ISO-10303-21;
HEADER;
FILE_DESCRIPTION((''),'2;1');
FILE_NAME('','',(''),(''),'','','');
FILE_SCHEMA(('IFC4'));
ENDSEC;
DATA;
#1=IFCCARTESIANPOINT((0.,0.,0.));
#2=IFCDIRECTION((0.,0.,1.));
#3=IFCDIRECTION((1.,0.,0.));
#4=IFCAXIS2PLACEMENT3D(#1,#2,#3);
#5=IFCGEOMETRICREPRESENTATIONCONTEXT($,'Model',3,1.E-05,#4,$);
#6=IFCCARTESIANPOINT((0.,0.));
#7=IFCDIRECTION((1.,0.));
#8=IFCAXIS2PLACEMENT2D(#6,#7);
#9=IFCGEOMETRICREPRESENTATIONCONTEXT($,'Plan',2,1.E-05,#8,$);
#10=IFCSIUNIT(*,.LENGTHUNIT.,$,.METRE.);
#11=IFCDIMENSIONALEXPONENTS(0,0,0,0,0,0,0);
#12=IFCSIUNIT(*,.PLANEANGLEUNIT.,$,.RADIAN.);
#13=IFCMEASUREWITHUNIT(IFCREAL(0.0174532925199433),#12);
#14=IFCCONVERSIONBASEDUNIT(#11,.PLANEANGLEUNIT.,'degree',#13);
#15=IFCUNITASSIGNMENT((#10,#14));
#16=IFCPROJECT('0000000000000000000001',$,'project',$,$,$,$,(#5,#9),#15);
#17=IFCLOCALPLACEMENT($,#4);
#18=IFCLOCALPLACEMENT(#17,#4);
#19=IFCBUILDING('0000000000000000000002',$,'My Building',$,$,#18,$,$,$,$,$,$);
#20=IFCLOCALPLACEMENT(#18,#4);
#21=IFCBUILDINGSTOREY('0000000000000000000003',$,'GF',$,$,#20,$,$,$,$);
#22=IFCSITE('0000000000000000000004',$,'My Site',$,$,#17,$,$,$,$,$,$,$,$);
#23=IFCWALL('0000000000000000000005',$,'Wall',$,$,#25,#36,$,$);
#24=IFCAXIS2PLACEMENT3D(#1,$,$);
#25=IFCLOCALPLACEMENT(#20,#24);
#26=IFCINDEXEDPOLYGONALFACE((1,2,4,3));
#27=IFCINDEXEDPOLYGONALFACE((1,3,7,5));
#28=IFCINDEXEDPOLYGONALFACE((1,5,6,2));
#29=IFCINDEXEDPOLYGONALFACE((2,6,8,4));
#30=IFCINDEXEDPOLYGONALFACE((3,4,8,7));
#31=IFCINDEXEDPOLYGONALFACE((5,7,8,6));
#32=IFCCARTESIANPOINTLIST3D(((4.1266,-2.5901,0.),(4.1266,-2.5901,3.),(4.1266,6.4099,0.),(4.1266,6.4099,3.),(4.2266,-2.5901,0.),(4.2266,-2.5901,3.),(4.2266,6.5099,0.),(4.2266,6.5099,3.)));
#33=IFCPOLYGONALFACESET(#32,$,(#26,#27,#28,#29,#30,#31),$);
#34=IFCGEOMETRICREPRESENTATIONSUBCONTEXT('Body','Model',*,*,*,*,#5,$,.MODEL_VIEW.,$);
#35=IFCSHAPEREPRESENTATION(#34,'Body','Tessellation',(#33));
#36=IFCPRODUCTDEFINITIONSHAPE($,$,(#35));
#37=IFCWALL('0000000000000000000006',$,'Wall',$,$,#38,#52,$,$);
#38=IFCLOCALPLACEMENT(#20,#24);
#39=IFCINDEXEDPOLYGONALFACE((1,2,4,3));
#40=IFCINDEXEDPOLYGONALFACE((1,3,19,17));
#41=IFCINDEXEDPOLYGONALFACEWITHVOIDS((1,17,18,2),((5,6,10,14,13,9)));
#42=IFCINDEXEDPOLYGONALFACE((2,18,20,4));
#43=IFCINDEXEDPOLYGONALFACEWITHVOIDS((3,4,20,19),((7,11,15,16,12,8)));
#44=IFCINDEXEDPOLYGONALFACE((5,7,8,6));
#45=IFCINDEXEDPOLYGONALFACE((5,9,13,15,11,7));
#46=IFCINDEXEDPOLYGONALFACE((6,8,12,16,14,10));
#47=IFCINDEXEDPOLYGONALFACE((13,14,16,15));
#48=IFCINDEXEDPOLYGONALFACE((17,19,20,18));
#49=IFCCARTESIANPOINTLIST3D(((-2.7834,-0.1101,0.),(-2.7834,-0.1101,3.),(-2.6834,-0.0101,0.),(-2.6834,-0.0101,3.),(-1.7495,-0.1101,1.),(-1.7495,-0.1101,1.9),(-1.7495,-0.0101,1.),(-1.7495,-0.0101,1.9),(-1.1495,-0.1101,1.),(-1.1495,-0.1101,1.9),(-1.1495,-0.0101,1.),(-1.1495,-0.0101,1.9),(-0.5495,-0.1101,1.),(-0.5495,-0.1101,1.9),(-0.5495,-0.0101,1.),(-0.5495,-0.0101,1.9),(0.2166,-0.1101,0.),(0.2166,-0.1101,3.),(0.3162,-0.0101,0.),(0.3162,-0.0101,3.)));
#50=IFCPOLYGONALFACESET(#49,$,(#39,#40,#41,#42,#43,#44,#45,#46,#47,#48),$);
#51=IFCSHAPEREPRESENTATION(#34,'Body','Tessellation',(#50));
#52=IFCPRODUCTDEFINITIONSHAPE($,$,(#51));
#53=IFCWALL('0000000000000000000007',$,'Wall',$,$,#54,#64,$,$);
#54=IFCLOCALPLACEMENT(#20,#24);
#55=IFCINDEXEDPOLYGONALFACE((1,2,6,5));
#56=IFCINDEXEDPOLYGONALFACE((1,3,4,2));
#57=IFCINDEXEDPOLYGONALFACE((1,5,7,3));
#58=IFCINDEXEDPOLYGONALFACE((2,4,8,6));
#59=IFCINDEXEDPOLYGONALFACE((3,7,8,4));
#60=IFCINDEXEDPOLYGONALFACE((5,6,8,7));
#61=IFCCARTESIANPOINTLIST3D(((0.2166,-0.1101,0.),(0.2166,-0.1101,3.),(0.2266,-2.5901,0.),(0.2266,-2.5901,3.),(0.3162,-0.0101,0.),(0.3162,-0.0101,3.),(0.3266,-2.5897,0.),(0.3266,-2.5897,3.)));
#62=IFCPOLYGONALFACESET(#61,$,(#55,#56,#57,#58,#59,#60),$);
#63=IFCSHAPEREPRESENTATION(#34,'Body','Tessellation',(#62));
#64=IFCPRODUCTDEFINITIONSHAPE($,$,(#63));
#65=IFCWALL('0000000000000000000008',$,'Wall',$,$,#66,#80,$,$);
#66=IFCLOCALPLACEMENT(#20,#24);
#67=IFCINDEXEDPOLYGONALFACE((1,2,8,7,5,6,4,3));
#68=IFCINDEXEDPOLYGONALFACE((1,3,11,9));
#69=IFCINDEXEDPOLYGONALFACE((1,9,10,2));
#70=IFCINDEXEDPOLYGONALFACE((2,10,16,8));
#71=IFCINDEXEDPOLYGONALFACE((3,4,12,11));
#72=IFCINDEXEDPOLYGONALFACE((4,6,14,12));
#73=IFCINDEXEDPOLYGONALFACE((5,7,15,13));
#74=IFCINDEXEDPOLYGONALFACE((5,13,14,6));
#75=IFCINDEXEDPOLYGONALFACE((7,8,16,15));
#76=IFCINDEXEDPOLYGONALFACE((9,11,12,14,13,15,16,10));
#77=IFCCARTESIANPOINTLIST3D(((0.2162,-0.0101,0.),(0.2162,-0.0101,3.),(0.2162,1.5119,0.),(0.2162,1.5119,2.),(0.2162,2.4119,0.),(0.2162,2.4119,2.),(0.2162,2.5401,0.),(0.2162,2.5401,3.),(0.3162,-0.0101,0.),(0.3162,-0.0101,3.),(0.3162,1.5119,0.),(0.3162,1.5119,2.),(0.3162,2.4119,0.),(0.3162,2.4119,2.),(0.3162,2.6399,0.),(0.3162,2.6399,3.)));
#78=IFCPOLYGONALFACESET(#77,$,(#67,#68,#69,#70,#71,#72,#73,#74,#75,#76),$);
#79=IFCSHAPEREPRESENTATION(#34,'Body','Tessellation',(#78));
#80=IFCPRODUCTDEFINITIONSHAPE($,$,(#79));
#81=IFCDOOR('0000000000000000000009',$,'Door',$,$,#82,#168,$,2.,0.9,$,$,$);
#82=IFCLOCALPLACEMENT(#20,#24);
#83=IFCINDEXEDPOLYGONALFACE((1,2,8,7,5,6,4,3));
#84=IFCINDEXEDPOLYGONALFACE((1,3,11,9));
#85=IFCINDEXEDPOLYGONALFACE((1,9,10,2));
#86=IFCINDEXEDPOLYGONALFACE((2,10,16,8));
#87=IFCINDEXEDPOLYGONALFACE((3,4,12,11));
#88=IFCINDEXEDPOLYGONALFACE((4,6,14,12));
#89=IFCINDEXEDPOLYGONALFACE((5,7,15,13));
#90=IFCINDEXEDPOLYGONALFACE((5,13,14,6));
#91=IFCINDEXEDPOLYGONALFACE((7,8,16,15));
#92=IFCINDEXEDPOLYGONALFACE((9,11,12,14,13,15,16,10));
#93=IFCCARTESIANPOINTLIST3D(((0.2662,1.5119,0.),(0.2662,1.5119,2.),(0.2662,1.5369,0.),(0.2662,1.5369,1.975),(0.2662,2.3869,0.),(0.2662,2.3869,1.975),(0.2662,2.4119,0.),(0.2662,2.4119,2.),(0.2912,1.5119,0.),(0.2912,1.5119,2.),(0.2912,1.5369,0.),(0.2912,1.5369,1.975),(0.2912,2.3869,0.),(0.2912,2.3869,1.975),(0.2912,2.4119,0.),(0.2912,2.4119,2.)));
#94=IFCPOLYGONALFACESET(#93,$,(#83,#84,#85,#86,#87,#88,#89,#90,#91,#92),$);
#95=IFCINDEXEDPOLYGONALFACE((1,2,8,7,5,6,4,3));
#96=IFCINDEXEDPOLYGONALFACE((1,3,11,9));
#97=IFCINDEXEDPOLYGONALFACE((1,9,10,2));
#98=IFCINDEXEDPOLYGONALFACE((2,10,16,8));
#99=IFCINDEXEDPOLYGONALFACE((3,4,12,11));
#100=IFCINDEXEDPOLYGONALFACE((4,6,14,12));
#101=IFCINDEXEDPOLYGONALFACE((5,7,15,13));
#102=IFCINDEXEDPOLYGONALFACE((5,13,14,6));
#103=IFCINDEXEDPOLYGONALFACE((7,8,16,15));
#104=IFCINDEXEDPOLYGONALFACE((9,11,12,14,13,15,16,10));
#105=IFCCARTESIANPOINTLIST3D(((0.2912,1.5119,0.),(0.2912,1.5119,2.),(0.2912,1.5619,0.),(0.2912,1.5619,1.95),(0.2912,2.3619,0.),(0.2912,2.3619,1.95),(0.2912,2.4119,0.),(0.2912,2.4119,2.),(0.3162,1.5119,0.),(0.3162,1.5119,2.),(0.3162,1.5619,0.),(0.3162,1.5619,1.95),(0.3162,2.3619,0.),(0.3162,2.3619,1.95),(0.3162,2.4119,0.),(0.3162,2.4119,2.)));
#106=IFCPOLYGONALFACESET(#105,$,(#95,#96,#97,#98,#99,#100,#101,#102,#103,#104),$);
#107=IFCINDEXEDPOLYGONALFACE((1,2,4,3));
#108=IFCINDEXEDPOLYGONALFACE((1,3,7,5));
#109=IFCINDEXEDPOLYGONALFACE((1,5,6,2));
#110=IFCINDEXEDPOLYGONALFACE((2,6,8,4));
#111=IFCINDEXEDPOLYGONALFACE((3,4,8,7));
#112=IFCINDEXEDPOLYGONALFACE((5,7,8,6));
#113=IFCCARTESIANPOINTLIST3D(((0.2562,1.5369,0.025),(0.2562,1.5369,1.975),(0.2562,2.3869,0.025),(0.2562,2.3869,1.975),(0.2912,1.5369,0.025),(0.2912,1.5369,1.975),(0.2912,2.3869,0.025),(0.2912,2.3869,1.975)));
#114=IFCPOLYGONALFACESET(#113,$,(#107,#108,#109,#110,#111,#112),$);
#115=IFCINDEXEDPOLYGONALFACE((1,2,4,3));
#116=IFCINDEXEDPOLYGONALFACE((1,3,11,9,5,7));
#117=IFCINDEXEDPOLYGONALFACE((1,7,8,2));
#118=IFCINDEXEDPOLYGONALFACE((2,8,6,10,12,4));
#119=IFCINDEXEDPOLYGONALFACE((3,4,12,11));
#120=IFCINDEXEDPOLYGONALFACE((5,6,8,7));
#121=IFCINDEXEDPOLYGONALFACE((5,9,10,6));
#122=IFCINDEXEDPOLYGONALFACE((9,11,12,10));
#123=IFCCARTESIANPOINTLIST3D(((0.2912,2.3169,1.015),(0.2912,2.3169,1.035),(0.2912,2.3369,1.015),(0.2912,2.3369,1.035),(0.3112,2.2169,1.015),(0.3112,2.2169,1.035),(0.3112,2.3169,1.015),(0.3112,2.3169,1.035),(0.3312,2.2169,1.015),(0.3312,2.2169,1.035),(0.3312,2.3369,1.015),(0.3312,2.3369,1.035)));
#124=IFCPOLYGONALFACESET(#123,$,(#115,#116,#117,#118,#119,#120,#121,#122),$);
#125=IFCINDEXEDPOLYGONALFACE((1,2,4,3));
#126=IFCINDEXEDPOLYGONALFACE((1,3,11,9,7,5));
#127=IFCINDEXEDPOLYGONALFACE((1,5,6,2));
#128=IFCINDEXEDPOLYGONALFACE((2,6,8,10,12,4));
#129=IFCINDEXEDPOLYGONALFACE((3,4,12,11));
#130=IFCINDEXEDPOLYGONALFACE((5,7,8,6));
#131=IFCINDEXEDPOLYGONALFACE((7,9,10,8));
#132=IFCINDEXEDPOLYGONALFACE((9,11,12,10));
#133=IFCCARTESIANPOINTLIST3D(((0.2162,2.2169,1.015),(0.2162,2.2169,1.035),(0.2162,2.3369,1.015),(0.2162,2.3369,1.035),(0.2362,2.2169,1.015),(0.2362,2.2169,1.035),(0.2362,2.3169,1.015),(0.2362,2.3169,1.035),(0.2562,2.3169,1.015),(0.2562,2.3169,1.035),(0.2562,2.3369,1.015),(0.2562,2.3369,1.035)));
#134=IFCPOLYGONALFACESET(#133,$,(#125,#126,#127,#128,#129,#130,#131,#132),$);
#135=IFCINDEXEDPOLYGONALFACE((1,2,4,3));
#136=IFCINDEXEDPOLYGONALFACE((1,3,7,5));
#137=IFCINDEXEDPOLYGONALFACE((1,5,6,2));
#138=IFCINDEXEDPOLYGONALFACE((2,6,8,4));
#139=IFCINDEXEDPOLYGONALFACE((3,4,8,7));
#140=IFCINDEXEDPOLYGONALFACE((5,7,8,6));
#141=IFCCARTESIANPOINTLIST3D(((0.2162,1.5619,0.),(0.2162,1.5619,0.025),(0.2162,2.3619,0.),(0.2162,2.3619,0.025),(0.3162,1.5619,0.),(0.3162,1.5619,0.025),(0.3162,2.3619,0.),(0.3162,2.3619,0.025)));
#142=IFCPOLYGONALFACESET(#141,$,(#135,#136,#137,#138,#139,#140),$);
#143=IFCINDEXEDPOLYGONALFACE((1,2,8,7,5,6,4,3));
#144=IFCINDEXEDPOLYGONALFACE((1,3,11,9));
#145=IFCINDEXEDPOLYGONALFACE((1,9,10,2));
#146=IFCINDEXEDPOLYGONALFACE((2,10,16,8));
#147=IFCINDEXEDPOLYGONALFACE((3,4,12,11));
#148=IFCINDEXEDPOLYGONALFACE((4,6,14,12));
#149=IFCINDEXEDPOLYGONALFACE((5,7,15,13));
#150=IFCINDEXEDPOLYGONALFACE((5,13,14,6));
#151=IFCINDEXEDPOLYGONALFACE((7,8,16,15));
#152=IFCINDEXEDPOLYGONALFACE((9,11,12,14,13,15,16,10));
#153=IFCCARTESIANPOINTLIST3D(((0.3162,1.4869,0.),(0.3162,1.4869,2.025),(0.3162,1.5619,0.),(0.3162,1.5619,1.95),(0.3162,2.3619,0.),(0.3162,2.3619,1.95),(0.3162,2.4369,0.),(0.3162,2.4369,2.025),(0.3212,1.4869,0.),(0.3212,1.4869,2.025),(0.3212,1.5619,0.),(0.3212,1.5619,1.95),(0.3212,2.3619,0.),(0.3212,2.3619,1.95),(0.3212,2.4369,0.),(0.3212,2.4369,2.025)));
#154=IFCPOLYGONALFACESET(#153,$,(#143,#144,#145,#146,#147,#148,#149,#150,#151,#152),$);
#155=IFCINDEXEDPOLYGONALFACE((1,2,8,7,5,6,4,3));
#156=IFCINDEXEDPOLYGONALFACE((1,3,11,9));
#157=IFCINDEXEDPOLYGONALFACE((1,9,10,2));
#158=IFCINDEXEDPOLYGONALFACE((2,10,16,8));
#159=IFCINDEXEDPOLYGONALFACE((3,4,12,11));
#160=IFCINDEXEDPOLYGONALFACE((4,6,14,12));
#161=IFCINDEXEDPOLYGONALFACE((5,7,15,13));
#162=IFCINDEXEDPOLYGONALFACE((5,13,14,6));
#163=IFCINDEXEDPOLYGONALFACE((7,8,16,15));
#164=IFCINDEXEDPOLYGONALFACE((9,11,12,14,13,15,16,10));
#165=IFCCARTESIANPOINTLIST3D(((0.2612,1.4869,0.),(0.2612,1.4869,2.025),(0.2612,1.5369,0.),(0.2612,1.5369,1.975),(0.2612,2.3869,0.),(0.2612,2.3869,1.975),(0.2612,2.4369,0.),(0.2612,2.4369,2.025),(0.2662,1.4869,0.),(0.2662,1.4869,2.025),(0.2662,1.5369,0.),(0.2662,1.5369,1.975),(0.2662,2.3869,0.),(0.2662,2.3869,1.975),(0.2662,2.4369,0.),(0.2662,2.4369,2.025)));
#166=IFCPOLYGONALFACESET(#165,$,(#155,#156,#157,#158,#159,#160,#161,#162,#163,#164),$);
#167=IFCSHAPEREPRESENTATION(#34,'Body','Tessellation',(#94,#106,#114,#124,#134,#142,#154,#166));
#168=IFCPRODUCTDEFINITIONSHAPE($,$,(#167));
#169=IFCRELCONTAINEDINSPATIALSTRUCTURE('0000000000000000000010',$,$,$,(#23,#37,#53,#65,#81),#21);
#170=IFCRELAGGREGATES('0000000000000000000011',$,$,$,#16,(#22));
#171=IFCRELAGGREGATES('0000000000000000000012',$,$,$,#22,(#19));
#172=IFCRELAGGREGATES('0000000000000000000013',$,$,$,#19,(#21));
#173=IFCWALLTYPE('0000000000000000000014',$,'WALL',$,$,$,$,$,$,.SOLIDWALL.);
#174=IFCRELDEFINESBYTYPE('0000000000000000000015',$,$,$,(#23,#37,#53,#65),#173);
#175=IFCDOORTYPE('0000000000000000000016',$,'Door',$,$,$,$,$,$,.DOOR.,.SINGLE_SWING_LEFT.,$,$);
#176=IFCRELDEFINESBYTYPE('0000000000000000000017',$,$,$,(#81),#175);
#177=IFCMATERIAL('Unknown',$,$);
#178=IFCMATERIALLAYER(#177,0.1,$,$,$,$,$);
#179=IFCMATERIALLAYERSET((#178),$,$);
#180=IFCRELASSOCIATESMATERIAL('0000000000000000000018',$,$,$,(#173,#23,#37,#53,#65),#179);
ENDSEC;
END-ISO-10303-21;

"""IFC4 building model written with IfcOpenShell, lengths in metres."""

from ifc_helpers import new_model, entity, si_unit, converted_unit, frame, origin_with_axes, origin_2d_with_axis, place, context, subcontext, project, spatial, line, indexed_curve, outline, extrude, shape, source, transform, mapped, material, layer, layer_set, layer_usage, type_object, type_shapes, element, fill, save


model = new_model("IFC4")

# Units and contexts
model_context = context("Model", 3, precision=1e-05, world=origin_with_axes())
plan_context = context("Plan", 2, precision=1e-05, world=origin_2d_with_axis())
body_context_1 = subcontext(model_context, "Body", "Model", "MODEL_VIEW")
body_context_2 = subcontext(plan_context, "Body", "Plan", "PLAN_VIEW")
ifc_project = project(units=[si_unit("LENGTHUNIT", "METRE"), converted_unit("PLANEANGLEUNIT", "degree", entity("IfcReal", 0.0174532925199433), si_unit("PLANEANGLEUNIT", "RADIAN"), dimensions=[0, 0, 0, 0, 0, 0, 0])], contexts=[model_context, plan_context])

# Site, building, storey
site_placement = place(None, origin_with_axes())
site = spatial("IfcSite", under=ifc_project, at=site_placement, Name="My Site")
building_placement = place(site_placement, origin_with_axes())
building = spatial("IfcBuilding", under=site, at=building_placement, Name="My Building")
storey_placement = place(building_placement, origin_with_axes())
storey = spatial("IfcBuildingStorey", under=building, at=storey_placement, Name="GF")

# Shared definitions
ifc_material_1 = material(Name="Unknown")

# Shared definitions
ifc_layer_1 = layer(ifc_material_1, 0.1)
ifc_layer_set_1 = layer_set([ifc_layer_1])
wall_type = type_object("IfcWallType", Name="WALL", PredefinedType="SOLIDWALL", material=ifc_layer_set_1)
shared_shape_1 = source(origin_with_axes(), body_context_1, "Body", "SweptSolid", [
    extrude(outline(indexed_curve([(0.0, 0.0), (0.9, 0.0), (0.9, 2.0), (0.0, 2.0)], segments=[line(1, 2, 3, 4, 1)])), frame((0.0, -0.6, 0.0), z_axis=(0.0, -1.0, 0.0), x_axis=(1.0, 0.0, 0.0)), (0.0, 0.0, -1.0), 1.2),
])
door_type = type_object("IfcDoorType", Name="Door", OperationType="SINGLE_SWING_LEFT", PredefinedType="DOOR")
shared_shape_2 = source(origin_with_axes(), body_context_1, "Body", "SweptSolid", [
    extrude(outline(indexed_curve([(0.0, 0.0), (0.0, 2.0), (0.9, 2.0), (0.9, 0.0), (0.875, 0.0), (0.875, 1.975), (0.025, 1.975), (0.025, 0.0)], segments=[line(1, 2, 3, 4, 5, 6, 7, 8, 1)])), frame((0.0, 0.025, 0.0), z_axis=(0.0, -1.0, 0.0), x_axis=(1.0, 0.0, 0.0)), (0.0, 0.0, -1.0), 0.025),
    extrude(outline(indexed_curve([(0.0, 0.0), (0.0, 2.0), (0.9, 2.0), (0.9, 0.0), (0.85, 0.0), (0.85, 1.95), (0.05, 1.95), (0.05, 0.0)], segments=[line(1, 2, 3, 4, 5, 6, 7, 8, 1)])), frame((0.0, 0.0, 0.0), z_axis=(0.0, -1.0, 0.0), x_axis=(1.0, 0.0, 0.0)), (0.0, 0.0, -1.0), 0.025),
    extrude(outline(indexed_curve([(0.0, 0.0), (0.85, 0.0), (0.85, 0.035), (0.0, 0.035)], segments=[line(1, 2, 3, 4, 1)])), frame((0.025, 0.025, 0.025), z_axis=(0.0, 0.0, 1.0), x_axis=(1.0, 0.0, 0.0)), (0.0, 0.0, 1.0), 1.95),
    extrude(outline(indexed_curve([(0.0, 0.0), (0.0, -0.04), (-0.12, -0.04), (-0.12, -0.02), (-0.02, -0.02), (-0.02, 0.0)], segments=[line(1, 2, 3, 4, 5, 6, 1)])), frame((0.825, 0.025, 1.015), z_axis=(0.0, 0.0, 1.0), x_axis=(1.0, 0.0, 0.0)), (0.0, 0.0, 1.0), 0.02),
    extrude(outline(indexed_curve([(0.0, 0.0), (0.0, 0.04), (-0.12, 0.04), (-0.12, 0.02), (-0.02, 0.02), (-0.02, 0.0)], segments=[line(1, 2, 3, 4, 5, 6, 1)])), frame((0.825, 0.06, 1.015), z_axis=(0.0, 0.0, 1.0), x_axis=(1.0, 0.0, 0.0)), (0.0, 0.0, 1.0), 0.02),
    extrude(outline(indexed_curve([(0.0, 0.0), (0.8, 0.0), (0.8, 0.1), (0.0, 0.1)], segments=[line(1, 2, 3, 4, 1)])), frame((0.05, 0.0, 0.0), z_axis=(0.0, 0.0, 1.0), x_axis=(1.0, 0.0, 0.0)), (0.0, 0.0, 1.0), 0.025),
    extrude(outline(indexed_curve([(0.0, 0.0), (0.0, 2.025), (0.95, 2.025), (0.95, 0.0), (0.875, 0.0), (0.875, 1.95), (0.075, 1.95), (0.075, 0.0)], segments=[line(1, 2, 3, 4, 5, 6, 7, 8, 1)])), frame((-0.025, -0.005, 0.0), z_axis=(0.0, -1.0, 0.0), x_axis=(1.0, 0.0, 0.0)), (0.0, 0.0, -1.0), 0.005),
    extrude(outline(indexed_curve([(0.0, 0.0), (0.0, 2.025), (0.95, 2.025), (0.95, 0.0), (0.9, 0.0), (0.9, 1.975), (0.05, 1.975), (0.05, 0.0)], segments=[line(1, 2, 3, 4, 5, 6, 7, 8, 1)])), frame((-0.025, 0.05, 0.0), z_axis=(0.0, -1.0, 0.0), x_axis=(1.0, 0.0, 0.0)), (0.0, 0.0, -1.0), 0.005),
])
shared_shape_3 = source(origin_with_axes(), body_context_2, "Body", "Curve2D", [
    entity("IfcIndexedPolyCurve", entity("IfcCartesianPointList2D", [[0.0, 0.0], [0.0, 0.05], [0.025, 0.05], [0.025, 0.025], [0.05, 0.025], [0.05, 0.0]]), [entity("IfcLineIndex", [1, 2, 3, 4, 5, 6, 1])]),
    entity("IfcIndexedPolyCurve", entity("IfcCartesianPointList2D", [[0.9, 0.0], [0.9, 0.05], [0.875, 0.05], [0.875, 0.025], [0.85, 0.025], [0.85, 0.0]]), [entity("IfcLineIndex", [1, 2, 3, 4, 5, 6, 1])]),
    entity("IfcTrimmedCurve", entity("IfcEllipse", entity("IfcAxis2Placement2D", entity("IfcCartesianPoint", [0.06, 0.05]), entity("IfcDirection", [1.0, 0.0])), 0.815, 0.85), [entity("IfcCartesianPoint", [0.875, 0.05])], [entity("IfcCartesianPoint", [0.06, 0.9])], True, "CARTESIAN"),
    entity("IfcIndexedPolyCurve", entity("IfcCartesianPointList2D", [[0.025, 0.05], [0.06, 0.05], [0.06, 0.9], [0.025, 0.9]]), [entity("IfcLineIndex", [1, 2, 3, 4, 1])]),
])
type_shapes(door_type, [shared_shape_2, shared_shape_3])

# Wall
ifc_layer_usage_1 = layer_usage(ifc_layer_set_1, "AXIS2", "POSITIVE", 0.0)
wall_1_placement = place(storey_placement, frame((4.2266, -2.5901, 0.0), z_axis=(0.0, 0.0, 1.0), x_axis=(0.0, 1.0, 0.0)))
element("IfcWall", 1, at=wall_1_placement, inside=storey, type_object=wall_type, material=ifc_layer_usage_1, Name="Wall", context=body_context_1, shape_type="SweptSolid", body=[
    extrude(outline(indexed_curve([(0.0, 0.0), (0.0, 0.1), (9.0, 0.1), (9.1, 0.0)], segments=[line(1, 2, 3, 4, 1)])), origin_with_axes(), (0.0, 0.0, 1.0), 3.0),
])

# Wall, openings
ifc_layer_usage_2 = layer_usage(ifc_layer_set_1, "AXIS2", "POSITIVE", 0.0)
wall_2_placement = place(storey_placement, frame((-2.7834, -0.1101, 0.0), z_axis=(0.0, 0.0, 1.0), x_axis=(1.0, 0.0, 0.0)))
wall_2 = element("IfcWall", 2, at=wall_2_placement, inside=storey, type_object=wall_type, material=ifc_layer_usage_2, Name="Wall", context=body_context_1, shape_type="SweptSolid", body=[
    extrude(outline(indexed_curve([(0.0, 0.0), (0.1, 0.1), (3.0996, 0.1), (3.0, 0.0)], segments=[line(1, 2, 3, 4, 1)])), origin_with_axes(), (0.0, 0.0, 1.0), 3.0),
])
shared_shape_4 = source(origin_with_axes(), body_context_1, "Body", "SweptSolid", [
    extrude(outline(indexed_curve([(0.0, 0.0), (0.6, 0.0), (0.6, 0.9), (0.0, 0.9)], segments=[line(1, 2, 3, 4, 1)])), frame((0.0, -0.6, 0.0), z_axis=(0.0, -1.0, 0.0), x_axis=(1.0, 0.0, 0.0)), (0.0, 0.0, -1.0), 1.2),
])
opening_1_placement = place(wall_2_placement, frame((1.0339, 0.0, 1.0), z_axis=(0.0, 0.0, 1.0), x_axis=(1.0, 0.0, 0.0)))
element("IfcOpeningElement", 3, at=opening_1_placement, cuts=wall_2, PredefinedType="OPENING", context=body_context_1, shape_type="MappedRepresentation", body=[
    mapped(shared_shape_4, transform((0.0, 0.0, 0.0), x_axis=(1.0, 0.0, 0.0), y_axis=(0.0, 1.0, 0.0), z_axis=(0.0, 0.0, 1.0), scale=1.0)),
])
opening_2_placement = place(wall_2_placement, frame((1.6339, 0.0, 1.0), z_axis=(0.0, 0.0, 1.0), x_axis=(1.0, 0.0, 0.0)))
element("IfcOpeningElement", 4, at=opening_2_placement, cuts=wall_2, PredefinedType="OPENING", context=body_context_1, shape_type="MappedRepresentation", body=[
    mapped(shared_shape_4, transform((0.0, 0.0, 0.0), x_axis=(1.0, 0.0, 0.0), y_axis=(0.0, 1.0, 0.0), z_axis=(0.0, 0.0, 1.0), scale=1.0)),
])

# Wall
ifc_layer_usage_3 = layer_usage(ifc_layer_set_1, "AXIS2", "POSITIVE", 0.0)
wall_3_placement = place(storey_placement, frame((0.2166, -0.1101, 0.0), z_axis=(0.0, 0.0, 1.0), x_axis=(0.004032, -0.999992, 0.0)))
element("IfcWall", 5, at=wall_3_placement, inside=storey, type_object=wall_type, material=ifc_layer_usage_3, Name="Wall", context=body_context_1, shape_type="SweptSolid", body=[
    extrude(outline(indexed_curve([(0.0, 0.0), (-0.0996, 0.1), (2.48, 0.1), (2.48, 0.0)], segments=[line(1, 2, 3, 4, 1)])), origin_with_axes(), (0.0, 0.0, 1.0), 3.0),
])

# Wall, opening, door
ifc_layer_usage_4 = layer_usage(ifc_layer_set_1, "AXIS2", "POSITIVE", 0.0)
wall_4_placement = place(storey_placement, frame((0.3162, -0.0101, 0.0), z_axis=(0.0, 0.0, 1.0), x_axis=(0.0, 1.0, 0.0)))
wall_4 = element("IfcWall", 6, at=wall_4_placement, inside=storey, type_object=wall_type, material=ifc_layer_usage_4, Name="Wall", context=body_context_1, shape_type="SweptSolid", body=[
    extrude(outline(indexed_curve([(0.0, 0.0), (0.0, 0.1), (2.5502, 0.1), (2.65, 0.0)], segments=[line(1, 2, 3, 4, 1)])), origin_with_axes(), (0.0, 0.0, 1.0), 3.0),
])
opening_3_placement = place(wall_4_placement, frame((1.522, 0.0, 0.0), z_axis=(0.0, 0.0, 1.0), x_axis=(1.0, 0.0, 0.0)))
opening_3 = element("IfcOpeningElement", 7, at=opening_3_placement, cuts=wall_4, PredefinedType="OPENING", context=body_context_1, shape_type="MappedRepresentation", body=[
    mapped(shared_shape_1, transform((0.0, 0.0, 0.0), x_axis=(1.0, 0.0, 0.0), y_axis=(0.0, 1.0, 0.0), z_axis=(0.0, 0.0, 1.0), scale=1.0)),
])
door_1_placement = place(opening_3_placement, frame((0.0, 0.0, 0.0), z_axis=(0.0, 0.0, 1.0), x_axis=(1.0, 0.0, 0.0)))
door_1 = element("IfcDoor", 8, at=door_1_placement, inside=storey, type_object=door_type, Name="Door", OverallHeight=2.0, OverallWidth=0.9, shapes=[
    shape(body_context_1, "Body", "MappedRepresentation", [mapped(shared_shape_2, transform((0.0, 0.0, 0.0), x_axis=(1.0, 0.0, 0.0), y_axis=(0.0, 1.0, 0.0), z_axis=(0.0, 0.0, 1.0), scale=1.0))]),
    shape(body_context_2, "Body", "MappedRepresentation", [mapped(shared_shape_3, transform((0.0, 0.0, 0.0), x_axis=(1.0, 0.0, 0.0), y_axis=(0.0, 1.0, 0.0), z_axis=(0.0, 0.0, 1.0), scale=1.0))]),
])
fill(opening_3, door_1)

save(model, "model.ifc")
